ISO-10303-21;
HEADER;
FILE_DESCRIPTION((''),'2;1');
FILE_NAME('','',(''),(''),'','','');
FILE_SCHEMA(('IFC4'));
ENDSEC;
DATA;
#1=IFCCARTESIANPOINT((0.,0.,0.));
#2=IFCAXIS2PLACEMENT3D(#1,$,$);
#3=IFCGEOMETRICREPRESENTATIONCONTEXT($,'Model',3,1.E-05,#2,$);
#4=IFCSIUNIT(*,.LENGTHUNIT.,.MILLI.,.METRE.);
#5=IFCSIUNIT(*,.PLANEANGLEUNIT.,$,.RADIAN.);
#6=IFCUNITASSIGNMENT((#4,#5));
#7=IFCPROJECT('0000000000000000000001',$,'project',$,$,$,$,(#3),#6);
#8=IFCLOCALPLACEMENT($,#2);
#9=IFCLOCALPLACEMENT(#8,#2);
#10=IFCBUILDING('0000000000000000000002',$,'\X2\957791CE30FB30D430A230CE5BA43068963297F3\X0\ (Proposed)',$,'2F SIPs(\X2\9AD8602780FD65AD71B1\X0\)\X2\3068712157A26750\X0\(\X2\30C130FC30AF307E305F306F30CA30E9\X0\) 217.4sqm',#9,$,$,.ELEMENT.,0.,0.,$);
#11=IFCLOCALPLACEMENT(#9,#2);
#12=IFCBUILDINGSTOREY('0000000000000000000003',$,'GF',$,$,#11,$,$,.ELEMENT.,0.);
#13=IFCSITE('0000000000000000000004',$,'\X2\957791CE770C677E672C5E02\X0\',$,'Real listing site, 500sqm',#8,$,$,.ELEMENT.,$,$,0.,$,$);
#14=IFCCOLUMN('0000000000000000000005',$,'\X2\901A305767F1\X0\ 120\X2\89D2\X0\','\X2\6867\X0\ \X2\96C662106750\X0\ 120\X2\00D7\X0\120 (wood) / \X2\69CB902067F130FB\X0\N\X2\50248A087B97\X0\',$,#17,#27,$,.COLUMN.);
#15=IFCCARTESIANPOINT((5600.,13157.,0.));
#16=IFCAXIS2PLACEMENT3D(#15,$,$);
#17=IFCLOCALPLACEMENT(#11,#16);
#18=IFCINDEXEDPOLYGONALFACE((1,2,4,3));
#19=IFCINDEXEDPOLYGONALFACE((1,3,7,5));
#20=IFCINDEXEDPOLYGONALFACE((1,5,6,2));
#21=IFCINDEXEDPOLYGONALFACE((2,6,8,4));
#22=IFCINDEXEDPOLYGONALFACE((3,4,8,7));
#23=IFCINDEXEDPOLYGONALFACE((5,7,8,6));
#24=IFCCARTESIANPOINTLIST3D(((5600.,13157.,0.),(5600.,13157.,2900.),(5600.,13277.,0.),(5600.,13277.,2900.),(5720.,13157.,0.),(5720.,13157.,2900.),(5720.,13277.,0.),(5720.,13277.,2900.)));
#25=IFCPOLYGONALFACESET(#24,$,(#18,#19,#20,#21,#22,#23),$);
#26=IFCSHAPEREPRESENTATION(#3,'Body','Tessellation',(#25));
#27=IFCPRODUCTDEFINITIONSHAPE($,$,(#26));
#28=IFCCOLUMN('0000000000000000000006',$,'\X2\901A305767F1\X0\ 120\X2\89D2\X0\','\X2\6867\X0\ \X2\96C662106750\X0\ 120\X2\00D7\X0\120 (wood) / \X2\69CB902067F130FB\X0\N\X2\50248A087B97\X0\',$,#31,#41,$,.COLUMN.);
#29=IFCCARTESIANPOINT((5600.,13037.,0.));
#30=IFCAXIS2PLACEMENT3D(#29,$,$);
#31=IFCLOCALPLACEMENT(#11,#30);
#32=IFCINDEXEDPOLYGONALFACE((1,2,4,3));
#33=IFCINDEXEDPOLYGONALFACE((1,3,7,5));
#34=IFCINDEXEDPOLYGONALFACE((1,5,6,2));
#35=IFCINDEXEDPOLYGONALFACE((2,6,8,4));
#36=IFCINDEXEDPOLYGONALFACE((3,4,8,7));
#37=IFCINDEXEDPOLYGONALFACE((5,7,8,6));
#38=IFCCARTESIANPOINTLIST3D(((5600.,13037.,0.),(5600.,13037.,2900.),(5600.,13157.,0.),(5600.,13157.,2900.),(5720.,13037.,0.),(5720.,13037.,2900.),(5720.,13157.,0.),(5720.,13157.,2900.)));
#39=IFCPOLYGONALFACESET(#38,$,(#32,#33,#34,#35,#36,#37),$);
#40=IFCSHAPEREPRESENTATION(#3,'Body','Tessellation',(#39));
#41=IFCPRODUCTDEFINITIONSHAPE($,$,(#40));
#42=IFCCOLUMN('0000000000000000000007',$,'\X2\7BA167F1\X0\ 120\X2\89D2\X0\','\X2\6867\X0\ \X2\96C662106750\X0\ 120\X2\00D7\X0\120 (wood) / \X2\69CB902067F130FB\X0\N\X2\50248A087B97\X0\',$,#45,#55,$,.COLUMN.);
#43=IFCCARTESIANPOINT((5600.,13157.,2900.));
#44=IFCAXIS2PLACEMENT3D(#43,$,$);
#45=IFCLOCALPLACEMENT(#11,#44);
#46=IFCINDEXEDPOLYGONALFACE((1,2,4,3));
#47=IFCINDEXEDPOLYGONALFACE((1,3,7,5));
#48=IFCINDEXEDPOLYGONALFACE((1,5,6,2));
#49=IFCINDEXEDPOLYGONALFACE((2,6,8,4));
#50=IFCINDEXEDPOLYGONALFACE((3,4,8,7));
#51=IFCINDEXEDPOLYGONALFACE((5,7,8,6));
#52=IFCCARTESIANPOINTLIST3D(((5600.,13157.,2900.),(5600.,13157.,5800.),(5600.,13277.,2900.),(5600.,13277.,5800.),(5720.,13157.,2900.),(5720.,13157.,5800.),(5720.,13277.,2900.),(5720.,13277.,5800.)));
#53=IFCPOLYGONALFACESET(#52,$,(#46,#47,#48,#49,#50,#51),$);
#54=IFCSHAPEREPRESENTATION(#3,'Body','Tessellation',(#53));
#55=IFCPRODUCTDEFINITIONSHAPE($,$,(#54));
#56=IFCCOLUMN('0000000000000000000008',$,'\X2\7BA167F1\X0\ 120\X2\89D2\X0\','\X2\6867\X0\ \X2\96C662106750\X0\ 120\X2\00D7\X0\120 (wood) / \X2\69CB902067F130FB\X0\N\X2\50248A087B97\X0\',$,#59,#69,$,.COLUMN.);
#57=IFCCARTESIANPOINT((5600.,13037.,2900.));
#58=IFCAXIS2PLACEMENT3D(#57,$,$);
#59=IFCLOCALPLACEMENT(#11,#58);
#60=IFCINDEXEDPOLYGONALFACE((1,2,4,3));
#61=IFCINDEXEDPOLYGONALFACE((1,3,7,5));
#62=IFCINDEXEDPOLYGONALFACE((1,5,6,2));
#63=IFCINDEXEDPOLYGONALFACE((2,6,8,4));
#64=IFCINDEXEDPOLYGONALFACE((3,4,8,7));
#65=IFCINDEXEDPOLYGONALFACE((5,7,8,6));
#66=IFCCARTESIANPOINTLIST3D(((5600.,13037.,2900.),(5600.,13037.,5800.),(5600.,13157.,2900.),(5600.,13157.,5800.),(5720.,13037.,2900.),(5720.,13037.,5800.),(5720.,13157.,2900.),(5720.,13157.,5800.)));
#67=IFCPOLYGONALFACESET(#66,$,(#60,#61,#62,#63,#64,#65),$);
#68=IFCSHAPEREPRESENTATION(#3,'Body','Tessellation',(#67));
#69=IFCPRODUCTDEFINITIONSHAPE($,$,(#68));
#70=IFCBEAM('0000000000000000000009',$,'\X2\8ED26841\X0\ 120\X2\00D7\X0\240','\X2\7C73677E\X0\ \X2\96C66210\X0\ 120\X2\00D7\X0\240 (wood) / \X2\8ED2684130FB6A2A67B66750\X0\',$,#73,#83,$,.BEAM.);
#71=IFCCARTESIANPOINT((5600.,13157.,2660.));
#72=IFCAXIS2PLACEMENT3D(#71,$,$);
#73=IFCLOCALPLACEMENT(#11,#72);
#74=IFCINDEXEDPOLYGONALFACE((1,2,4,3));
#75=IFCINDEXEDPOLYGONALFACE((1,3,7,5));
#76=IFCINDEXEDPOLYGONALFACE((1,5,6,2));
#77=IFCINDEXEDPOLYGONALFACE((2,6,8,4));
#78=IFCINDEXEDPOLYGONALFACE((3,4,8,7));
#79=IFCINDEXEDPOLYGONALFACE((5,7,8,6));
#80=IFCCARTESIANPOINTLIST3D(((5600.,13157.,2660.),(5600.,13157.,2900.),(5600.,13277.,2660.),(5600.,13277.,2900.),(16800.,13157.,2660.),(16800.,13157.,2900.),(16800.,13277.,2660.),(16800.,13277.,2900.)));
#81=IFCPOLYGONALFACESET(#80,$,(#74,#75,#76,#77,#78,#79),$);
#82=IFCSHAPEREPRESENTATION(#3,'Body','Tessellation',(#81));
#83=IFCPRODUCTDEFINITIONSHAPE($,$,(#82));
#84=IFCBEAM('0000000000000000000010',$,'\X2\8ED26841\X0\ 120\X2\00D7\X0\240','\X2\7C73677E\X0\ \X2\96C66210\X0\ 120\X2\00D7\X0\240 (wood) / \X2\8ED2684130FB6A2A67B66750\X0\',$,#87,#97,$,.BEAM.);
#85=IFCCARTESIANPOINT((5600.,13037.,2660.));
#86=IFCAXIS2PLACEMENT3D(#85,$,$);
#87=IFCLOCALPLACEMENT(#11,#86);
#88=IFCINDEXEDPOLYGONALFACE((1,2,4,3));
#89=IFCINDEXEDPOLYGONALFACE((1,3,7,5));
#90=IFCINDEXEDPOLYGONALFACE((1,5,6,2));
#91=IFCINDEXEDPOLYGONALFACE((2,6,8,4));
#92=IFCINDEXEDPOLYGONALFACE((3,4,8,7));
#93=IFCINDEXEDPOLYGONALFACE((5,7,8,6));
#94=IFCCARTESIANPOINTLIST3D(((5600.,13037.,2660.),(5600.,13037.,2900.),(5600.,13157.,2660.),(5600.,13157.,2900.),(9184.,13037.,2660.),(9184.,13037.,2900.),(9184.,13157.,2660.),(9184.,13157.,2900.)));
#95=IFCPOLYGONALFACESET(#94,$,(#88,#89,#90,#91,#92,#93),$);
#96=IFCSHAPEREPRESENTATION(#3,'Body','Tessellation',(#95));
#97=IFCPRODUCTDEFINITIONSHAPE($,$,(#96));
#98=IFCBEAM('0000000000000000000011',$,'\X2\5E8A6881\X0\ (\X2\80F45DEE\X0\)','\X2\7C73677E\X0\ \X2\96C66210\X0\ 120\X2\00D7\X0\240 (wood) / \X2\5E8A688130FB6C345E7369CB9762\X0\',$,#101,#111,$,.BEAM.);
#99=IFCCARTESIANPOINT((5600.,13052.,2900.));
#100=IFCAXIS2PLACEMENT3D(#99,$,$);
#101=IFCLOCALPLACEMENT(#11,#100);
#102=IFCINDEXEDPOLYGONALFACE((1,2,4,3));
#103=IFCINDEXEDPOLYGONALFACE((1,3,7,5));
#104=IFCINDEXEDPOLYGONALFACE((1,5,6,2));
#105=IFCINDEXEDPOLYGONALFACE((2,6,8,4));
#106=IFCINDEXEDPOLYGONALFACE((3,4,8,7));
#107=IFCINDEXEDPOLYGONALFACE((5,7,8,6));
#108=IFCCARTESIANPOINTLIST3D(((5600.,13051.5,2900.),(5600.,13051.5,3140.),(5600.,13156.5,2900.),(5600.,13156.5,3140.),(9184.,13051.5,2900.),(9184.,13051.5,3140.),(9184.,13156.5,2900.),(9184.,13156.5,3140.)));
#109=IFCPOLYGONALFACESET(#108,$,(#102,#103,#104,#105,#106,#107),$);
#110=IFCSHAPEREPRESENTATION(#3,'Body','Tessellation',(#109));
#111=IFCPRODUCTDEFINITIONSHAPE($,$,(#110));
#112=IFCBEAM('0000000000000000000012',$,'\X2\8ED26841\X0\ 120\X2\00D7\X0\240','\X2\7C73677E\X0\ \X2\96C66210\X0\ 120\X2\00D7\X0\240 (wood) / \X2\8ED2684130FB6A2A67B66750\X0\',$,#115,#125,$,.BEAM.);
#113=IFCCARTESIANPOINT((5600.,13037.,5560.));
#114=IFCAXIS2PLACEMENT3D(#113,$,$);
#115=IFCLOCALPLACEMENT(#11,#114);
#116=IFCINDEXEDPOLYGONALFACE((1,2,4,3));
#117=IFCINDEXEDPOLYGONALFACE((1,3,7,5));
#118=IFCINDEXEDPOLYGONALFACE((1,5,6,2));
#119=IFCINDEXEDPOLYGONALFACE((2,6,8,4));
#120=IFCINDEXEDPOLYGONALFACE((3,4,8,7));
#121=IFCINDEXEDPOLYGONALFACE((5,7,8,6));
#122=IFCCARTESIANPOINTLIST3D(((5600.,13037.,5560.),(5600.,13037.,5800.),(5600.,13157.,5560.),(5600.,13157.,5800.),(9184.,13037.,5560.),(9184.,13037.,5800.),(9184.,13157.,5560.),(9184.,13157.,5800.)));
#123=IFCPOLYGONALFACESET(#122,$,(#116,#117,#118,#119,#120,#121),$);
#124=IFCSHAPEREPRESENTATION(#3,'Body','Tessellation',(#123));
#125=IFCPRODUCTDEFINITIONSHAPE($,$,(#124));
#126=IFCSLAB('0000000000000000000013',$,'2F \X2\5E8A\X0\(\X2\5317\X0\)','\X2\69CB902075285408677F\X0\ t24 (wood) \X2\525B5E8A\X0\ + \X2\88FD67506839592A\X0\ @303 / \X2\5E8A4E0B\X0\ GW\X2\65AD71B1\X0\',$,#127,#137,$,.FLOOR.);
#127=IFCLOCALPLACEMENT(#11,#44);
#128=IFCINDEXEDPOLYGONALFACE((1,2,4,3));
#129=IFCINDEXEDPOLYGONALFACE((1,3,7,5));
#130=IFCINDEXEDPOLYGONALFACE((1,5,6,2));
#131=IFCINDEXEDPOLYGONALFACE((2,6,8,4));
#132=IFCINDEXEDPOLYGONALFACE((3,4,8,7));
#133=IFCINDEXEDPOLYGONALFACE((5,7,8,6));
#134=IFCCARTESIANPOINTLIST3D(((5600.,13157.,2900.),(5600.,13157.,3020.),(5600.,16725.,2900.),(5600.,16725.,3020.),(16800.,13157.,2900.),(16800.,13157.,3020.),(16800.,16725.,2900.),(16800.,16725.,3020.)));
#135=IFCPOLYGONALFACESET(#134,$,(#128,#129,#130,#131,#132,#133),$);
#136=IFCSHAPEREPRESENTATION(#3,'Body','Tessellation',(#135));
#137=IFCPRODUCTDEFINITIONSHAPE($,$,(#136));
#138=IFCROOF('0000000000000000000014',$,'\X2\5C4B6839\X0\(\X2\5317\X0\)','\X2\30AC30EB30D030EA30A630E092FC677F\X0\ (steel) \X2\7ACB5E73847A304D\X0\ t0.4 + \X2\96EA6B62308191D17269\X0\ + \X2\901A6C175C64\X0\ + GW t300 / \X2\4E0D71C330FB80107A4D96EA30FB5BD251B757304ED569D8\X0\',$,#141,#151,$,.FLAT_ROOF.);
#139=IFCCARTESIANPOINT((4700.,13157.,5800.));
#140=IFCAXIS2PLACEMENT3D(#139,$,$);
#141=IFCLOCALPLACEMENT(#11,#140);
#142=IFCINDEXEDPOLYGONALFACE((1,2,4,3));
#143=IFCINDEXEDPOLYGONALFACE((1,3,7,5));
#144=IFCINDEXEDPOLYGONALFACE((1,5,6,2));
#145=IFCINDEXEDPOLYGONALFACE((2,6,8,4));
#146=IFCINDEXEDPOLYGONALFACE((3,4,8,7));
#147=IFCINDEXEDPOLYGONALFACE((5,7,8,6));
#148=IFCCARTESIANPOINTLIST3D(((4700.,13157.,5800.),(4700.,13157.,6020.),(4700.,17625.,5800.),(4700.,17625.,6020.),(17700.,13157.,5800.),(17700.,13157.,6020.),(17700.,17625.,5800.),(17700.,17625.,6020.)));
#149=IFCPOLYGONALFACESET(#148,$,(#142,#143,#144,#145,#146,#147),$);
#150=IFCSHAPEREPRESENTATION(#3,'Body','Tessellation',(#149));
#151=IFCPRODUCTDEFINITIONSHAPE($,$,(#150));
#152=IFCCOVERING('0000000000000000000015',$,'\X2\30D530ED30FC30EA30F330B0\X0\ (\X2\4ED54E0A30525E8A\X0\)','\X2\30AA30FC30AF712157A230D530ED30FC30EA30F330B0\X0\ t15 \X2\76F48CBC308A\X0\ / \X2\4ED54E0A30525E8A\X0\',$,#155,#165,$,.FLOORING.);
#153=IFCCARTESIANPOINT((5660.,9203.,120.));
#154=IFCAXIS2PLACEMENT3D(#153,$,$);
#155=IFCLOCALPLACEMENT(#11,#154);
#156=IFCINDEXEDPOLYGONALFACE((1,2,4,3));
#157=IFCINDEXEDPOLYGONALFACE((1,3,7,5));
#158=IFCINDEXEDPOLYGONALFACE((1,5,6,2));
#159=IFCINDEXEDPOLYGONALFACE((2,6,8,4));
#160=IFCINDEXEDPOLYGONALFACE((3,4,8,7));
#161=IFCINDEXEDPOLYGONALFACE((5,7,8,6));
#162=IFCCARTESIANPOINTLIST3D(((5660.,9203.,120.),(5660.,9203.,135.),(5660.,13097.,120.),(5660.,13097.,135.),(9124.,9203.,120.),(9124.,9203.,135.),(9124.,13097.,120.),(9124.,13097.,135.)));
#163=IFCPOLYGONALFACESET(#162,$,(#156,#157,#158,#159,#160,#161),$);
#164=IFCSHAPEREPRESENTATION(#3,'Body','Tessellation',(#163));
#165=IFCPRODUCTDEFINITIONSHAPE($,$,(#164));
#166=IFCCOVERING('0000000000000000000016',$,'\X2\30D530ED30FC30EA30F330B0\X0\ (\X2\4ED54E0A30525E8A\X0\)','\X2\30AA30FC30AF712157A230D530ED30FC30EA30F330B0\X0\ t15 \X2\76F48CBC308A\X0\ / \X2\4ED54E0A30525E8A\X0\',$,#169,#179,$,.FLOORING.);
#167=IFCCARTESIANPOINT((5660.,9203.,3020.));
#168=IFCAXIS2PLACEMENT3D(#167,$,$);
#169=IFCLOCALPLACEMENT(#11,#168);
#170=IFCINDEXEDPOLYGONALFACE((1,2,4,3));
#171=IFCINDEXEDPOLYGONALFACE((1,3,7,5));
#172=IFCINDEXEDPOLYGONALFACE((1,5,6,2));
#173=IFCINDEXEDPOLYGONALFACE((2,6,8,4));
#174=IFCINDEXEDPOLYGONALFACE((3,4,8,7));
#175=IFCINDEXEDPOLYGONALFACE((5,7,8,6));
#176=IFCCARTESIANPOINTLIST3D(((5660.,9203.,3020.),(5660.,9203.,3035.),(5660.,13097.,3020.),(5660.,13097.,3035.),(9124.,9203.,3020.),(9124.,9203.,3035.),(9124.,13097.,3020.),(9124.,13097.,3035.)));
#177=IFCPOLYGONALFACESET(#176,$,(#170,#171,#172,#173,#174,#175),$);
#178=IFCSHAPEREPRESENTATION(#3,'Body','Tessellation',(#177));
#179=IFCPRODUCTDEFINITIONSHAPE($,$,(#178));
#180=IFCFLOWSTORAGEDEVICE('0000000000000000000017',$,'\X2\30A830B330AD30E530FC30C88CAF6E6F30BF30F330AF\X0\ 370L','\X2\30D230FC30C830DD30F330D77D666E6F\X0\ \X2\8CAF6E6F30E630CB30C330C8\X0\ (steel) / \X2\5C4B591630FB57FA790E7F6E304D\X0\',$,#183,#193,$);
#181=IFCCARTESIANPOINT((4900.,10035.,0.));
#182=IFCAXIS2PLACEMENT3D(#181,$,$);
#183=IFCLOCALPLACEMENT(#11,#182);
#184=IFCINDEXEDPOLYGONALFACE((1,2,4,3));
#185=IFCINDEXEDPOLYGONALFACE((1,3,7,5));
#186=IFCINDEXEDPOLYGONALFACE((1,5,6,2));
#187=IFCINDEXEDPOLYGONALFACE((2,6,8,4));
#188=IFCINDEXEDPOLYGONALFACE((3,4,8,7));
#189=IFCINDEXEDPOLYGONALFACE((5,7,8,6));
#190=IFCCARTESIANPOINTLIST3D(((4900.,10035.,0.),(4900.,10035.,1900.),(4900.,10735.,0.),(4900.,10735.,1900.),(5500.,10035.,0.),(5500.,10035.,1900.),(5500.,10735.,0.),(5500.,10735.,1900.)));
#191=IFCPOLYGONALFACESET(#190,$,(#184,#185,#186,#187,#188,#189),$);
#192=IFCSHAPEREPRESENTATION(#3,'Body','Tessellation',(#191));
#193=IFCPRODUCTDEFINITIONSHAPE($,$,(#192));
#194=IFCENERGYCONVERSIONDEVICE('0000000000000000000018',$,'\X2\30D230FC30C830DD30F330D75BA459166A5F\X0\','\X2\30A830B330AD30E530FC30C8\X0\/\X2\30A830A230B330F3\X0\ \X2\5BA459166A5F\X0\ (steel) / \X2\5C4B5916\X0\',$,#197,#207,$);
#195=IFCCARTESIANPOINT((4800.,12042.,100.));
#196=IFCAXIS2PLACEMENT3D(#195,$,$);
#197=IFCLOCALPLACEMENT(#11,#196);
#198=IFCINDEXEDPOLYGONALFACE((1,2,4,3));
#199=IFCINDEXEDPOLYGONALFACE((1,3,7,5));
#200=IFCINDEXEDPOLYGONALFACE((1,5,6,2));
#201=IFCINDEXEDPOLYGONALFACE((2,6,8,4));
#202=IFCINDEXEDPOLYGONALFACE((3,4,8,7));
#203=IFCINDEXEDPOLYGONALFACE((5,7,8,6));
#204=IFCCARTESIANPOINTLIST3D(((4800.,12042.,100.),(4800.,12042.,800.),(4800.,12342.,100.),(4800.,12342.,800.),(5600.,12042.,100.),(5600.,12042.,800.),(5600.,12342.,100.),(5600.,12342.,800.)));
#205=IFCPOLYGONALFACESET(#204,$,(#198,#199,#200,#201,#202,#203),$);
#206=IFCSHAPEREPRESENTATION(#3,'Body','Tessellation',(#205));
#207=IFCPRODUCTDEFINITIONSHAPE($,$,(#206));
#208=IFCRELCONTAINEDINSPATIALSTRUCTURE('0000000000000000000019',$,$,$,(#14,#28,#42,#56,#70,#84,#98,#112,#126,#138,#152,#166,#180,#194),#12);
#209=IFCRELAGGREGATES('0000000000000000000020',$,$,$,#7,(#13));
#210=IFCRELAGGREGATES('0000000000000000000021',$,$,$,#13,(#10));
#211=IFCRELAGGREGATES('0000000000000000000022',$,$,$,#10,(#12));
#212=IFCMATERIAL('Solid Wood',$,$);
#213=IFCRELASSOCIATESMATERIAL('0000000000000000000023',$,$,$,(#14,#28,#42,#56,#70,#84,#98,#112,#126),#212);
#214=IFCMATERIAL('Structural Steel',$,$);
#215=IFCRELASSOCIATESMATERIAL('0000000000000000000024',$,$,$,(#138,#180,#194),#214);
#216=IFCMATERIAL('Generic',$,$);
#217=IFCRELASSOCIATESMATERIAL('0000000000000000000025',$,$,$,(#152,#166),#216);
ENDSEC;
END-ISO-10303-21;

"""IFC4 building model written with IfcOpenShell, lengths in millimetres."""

from ifc_helpers import new_model, si_unit, frame, frame_2d, origin, place, context, project, spatial, rectangle, extrude, material, element, save


model = new_model("IFC4")

# Units and contexts
model_context = context("Model", 3, precision=1e-05, world=origin())
ifc_project = project(units=[si_unit("LENGTHUNIT", "METRE", prefix="MILLI"), si_unit("PLANEANGLEUNIT", "RADIAN")], contexts=[model_context])

# Site, building, storey
site_placement = place(None, origin())
site = spatial("IfcSite", under=ifc_project, at=site_placement, Name="長野県松本市", ObjectType="Real listing site, 500sqm", CompositionType="ELEMENT", RefElevation=0.0)
building_placement = place(site_placement, origin())
building = spatial("IfcBuilding", under=site, at=building_placement, Name="長野・ピアノ室と防音 (Proposed)", ObjectType="2F SIPs(高性能断熱)と無垢材(チークまたはナラ) 217.4sqm", CompositionType="ELEMENT", ElevationOfRefHeight=0.0, ElevationOfTerrain=0.0)
storey_placement = place(building_placement, origin())
storey = spatial("IfcBuildingStorey", under=building, at=storey_placement, Name="GF", CompositionType="ELEMENT", Elevation=0.0)

# Columns
ifc_material_1 = material(Name="Solid Wood")
column_1_placement = place(storey_placement, frame((5600.0, 13157.0, 0.0)))
element("IfcColumn", 1, at=column_1_placement, inside=storey, material=ifc_material_1, Name="通し柱 120角", Description="桧 集成材 120×120 (wood) / 構造柱・N値計算", PredefinedType="COLUMN", context=model_context, shape_type="SweptSolid", body=[
    extrude(rectangle(XDim=120.0, YDim=120.0, at=frame_2d((60.0, 60.0))), frame((5600.0, 13157.0, 0.0)), (0.0, 0.0, 1.0), 2900.0),
])
column_2_placement = place(storey_placement, frame((5600.0, 13037.0, 0.0)))
element("IfcColumn", 2, at=column_2_placement, inside=storey, material=ifc_material_1, Name="通し柱 120角", Description="桧 集成材 120×120 (wood) / 構造柱・N値計算", PredefinedType="COLUMN", context=model_context, shape_type="SweptSolid", body=[
    extrude(rectangle(XDim=120.0, YDim=120.0, at=frame_2d((60.0, 60.0))), frame((5600.0, 13037.0, 0.0)), (0.0, 0.0, 1.0), 2900.0),
])
column_3_placement = place(storey_placement, frame((5600.0, 13157.0, 2900.0)))
element("IfcColumn", 3, at=column_3_placement, inside=storey, material=ifc_material_1, Name="管柱 120角", Description="桧 集成材 120×120 (wood) / 構造柱・N値計算", PredefinedType="COLUMN", context=model_context, shape_type="SweptSolid", body=[
    extrude(rectangle(XDim=120.0, YDim=120.0, at=frame_2d((60.0, 60.0))), frame((5600.0, 13157.0, 2900.0)), (0.0, 0.0, 1.0), 2900.0),
])
column_4_placement = place(storey_placement, frame((5600.0, 13037.0, 2900.0)))
element("IfcColumn", 4, at=column_4_placement, inside=storey, material=ifc_material_1, Name="管柱 120角", Description="桧 集成材 120×120 (wood) / 構造柱・N値計算", PredefinedType="COLUMN", context=model_context, shape_type="SweptSolid", body=[
    extrude(rectangle(XDim=120.0, YDim=120.0, at=frame_2d((60.0, 60.0))), frame((5600.0, 13037.0, 2900.0)), (0.0, 0.0, 1.0), 2900.0),
])

# Beams
beam_1_placement = place(storey_placement, frame((5600.0, 13157.0, 2660.0)))
element("IfcBeam", 5, at=beam_1_placement, inside=storey, material=ifc_material_1, Name="軒桁 120×240", Description="米松 集成 120×240 (wood) / 軒桁・横架材", PredefinedType="BEAM", context=model_context, shape_type="SweptSolid", body=[
    extrude(rectangle(XDim=11200.0, YDim=120.0, at=frame_2d((5600.0, 60.0))), frame((5600.0, 13157.0, 2660.0)), (0.0, 0.0, 1.0), 240.0),
])
beam_2_placement = place(storey_placement, frame((5600.0, 13037.0, 2660.0)))
element("IfcBeam", 6, at=beam_2_placement, inside=storey, material=ifc_material_1, Name="軒桁 120×240", Description="米松 集成 120×240 (wood) / 軒桁・横架材", PredefinedType="BEAM", context=model_context, shape_type="SweptSolid", body=[
    extrude(rectangle(XDim=3584.0, YDim=120.0, at=frame_2d((1792.0, 60.0))), frame((5600.0, 13037.0, 2660.0)), (0.0, 0.0, 1.0), 240.0),
])
beam_3_placement = place(storey_placement, frame((5600.0, 13052.0, 2900.0)))
element("IfcBeam", 7, at=beam_3_placement, inside=storey, material=ifc_material_1, Name="床梁 (胴差)", Description="米松 集成 120×240 (wood) / 床梁・水平構面", PredefinedType="BEAM", context=model_context, shape_type="SweptSolid", body=[
    extrude(rectangle(XDim=3584.0, YDim=105.0, at=frame_2d((1792.0, 52.0))), frame((5600.0, 13052.0, 2900.0)), (0.0, 0.0, 1.0), 240.0),
])
beam_4_placement = place(storey_placement, frame((5600.0, 13037.0, 5560.0)))
element("IfcBeam", 8, at=beam_4_placement, inside=storey, material=ifc_material_1, Name="軒桁 120×240", Description="米松 集成 120×240 (wood) / 軒桁・横架材", PredefinedType="BEAM", context=model_context, shape_type="SweptSolid", body=[
    extrude(rectangle(XDim=3584.0, YDim=120.0, at=frame_2d((1792.0, 60.0))), frame((5600.0, 13037.0, 5560.0)), (0.0, 0.0, 1.0), 240.0),
])

# Slab
slab_1_placement = place(storey_placement, frame((5600.0, 13157.0, 2900.0)))
element("IfcSlab", 9, at=slab_1_placement, inside=storey, material=ifc_material_1, Name="2F 床(北)", Description="構造用合板 t24 (wood) 剛床 + 製材根太 @303 / 床下 GW断熱", PredefinedType="FLOOR", context=model_context, shape_type="SweptSolid", body=[
    extrude(rectangle(XDim=11200.0, YDim=3568.0, at=frame_2d((5600.0, 1784.0))), frame((5600.0, 13157.0, 2900.0)), (0.0, 0.0, 1.0), 120.0),
])

# Roof
ifc_material_2 = material(Name="Structural Steel")
for number, where, name in (
    (10, (4700.0, 13157.0, 5800.0), "屋根(北)"),
):
    element("IfcRoof", number, at=place(storey_placement, frame(where)), inside=storey, material=ifc_material_2, Name=name, Description="ガルバリウム鋼板 (steel) 立平葺き t0.4 + 雪止め金物 + 通気層 + GW t300 / 不燃・耐積雪・寒冷地仕様", PredefinedType="FLAT_ROOF", context=model_context, shape_type="SweptSolid", body=[
        extrude(rectangle(XDim=13000.0, YDim=4468.0, at=frame_2d((6500.0, 2234.0))), frame((4700.0, 13157.0, 5800.0)), (0.0, 0.0, 1.0), 220.0),
    ])

# Coverings
ifc_material_3 = material(Name="Generic")
covering_1_placement = place(storey_placement, frame((5660.0, 9203.0, 120.0)))
element("IfcCovering", 11, at=covering_1_placement, inside=storey, material=ifc_material_3, Name="フローリング (仕上げ床)", Description="オーク無垢フローリング t15 直貼り / 仕上げ床", PredefinedType="FLOORING", context=model_context, shape_type="SweptSolid", body=[
    extrude(rectangle(XDim=3464.0, YDim=3894.0, at=frame_2d((1732.0, 1947.0))), frame((5660.0, 9203.0, 120.0)), (0.0, 0.0, 1.0), 15.0),
])
covering_2_placement = place(storey_placement, frame((5660.0, 9203.0, 3020.0)))
element("IfcCovering", 12, at=covering_2_placement, inside=storey, material=ifc_material_3, Name="フローリング (仕上げ床)", Description="オーク無垢フローリング t15 直貼り / 仕上げ床", PredefinedType="FLOORING", context=model_context, shape_type="SweptSolid", body=[
    extrude(rectangle(XDim=3464.0, YDim=3894.0, at=frame_2d((1732.0, 1947.0))), frame((5660.0, 9203.0, 3020.0)), (0.0, 0.0, 1.0), 15.0),
])

# Flow storage device
flow_storage_device_placement = place(storey_placement, frame((4900.0, 10035.0, 0.0)))
element("IfcFlowStorageDevice", 13, at=flow_storage_device_placement, inside=storey, material=ifc_material_2, Name="エコキュート貯湯タンク 370L", Description="ヒートポンプ給湯 貯湯ユニット (steel) / 屋外・基礎置き", context=model_context, shape_type="SweptSolid", body=[
    extrude(rectangle(XDim=600.0, YDim=700.0, at=frame_2d((300.0, 350.0))), frame((4900.0, 10035.0, 0.0)), (0.0, 0.0, 1.0), 1900.0),
])

# Energy conversion device
energy_conversion_device_placement = place(storey_placement, frame((4800.0, 12042.0, 100.0)))
element("IfcEnergyConversionDevice", 14, at=energy_conversion_device_placement, inside=storey, material=ifc_material_2, Name="ヒートポンプ室外機", Description="エコキュート/エアコン 室外機 (steel) / 屋外", context=model_context, shape_type="SweptSolid", body=[
    extrude(rectangle(XDim=800.0, YDim=300.0, at=frame_2d((400.0, 150.0))), frame((4800.0, 12042.0, 100.0)), (0.0, 0.0, 1.0), 700.0),
])

save(model, "model.ifc")
